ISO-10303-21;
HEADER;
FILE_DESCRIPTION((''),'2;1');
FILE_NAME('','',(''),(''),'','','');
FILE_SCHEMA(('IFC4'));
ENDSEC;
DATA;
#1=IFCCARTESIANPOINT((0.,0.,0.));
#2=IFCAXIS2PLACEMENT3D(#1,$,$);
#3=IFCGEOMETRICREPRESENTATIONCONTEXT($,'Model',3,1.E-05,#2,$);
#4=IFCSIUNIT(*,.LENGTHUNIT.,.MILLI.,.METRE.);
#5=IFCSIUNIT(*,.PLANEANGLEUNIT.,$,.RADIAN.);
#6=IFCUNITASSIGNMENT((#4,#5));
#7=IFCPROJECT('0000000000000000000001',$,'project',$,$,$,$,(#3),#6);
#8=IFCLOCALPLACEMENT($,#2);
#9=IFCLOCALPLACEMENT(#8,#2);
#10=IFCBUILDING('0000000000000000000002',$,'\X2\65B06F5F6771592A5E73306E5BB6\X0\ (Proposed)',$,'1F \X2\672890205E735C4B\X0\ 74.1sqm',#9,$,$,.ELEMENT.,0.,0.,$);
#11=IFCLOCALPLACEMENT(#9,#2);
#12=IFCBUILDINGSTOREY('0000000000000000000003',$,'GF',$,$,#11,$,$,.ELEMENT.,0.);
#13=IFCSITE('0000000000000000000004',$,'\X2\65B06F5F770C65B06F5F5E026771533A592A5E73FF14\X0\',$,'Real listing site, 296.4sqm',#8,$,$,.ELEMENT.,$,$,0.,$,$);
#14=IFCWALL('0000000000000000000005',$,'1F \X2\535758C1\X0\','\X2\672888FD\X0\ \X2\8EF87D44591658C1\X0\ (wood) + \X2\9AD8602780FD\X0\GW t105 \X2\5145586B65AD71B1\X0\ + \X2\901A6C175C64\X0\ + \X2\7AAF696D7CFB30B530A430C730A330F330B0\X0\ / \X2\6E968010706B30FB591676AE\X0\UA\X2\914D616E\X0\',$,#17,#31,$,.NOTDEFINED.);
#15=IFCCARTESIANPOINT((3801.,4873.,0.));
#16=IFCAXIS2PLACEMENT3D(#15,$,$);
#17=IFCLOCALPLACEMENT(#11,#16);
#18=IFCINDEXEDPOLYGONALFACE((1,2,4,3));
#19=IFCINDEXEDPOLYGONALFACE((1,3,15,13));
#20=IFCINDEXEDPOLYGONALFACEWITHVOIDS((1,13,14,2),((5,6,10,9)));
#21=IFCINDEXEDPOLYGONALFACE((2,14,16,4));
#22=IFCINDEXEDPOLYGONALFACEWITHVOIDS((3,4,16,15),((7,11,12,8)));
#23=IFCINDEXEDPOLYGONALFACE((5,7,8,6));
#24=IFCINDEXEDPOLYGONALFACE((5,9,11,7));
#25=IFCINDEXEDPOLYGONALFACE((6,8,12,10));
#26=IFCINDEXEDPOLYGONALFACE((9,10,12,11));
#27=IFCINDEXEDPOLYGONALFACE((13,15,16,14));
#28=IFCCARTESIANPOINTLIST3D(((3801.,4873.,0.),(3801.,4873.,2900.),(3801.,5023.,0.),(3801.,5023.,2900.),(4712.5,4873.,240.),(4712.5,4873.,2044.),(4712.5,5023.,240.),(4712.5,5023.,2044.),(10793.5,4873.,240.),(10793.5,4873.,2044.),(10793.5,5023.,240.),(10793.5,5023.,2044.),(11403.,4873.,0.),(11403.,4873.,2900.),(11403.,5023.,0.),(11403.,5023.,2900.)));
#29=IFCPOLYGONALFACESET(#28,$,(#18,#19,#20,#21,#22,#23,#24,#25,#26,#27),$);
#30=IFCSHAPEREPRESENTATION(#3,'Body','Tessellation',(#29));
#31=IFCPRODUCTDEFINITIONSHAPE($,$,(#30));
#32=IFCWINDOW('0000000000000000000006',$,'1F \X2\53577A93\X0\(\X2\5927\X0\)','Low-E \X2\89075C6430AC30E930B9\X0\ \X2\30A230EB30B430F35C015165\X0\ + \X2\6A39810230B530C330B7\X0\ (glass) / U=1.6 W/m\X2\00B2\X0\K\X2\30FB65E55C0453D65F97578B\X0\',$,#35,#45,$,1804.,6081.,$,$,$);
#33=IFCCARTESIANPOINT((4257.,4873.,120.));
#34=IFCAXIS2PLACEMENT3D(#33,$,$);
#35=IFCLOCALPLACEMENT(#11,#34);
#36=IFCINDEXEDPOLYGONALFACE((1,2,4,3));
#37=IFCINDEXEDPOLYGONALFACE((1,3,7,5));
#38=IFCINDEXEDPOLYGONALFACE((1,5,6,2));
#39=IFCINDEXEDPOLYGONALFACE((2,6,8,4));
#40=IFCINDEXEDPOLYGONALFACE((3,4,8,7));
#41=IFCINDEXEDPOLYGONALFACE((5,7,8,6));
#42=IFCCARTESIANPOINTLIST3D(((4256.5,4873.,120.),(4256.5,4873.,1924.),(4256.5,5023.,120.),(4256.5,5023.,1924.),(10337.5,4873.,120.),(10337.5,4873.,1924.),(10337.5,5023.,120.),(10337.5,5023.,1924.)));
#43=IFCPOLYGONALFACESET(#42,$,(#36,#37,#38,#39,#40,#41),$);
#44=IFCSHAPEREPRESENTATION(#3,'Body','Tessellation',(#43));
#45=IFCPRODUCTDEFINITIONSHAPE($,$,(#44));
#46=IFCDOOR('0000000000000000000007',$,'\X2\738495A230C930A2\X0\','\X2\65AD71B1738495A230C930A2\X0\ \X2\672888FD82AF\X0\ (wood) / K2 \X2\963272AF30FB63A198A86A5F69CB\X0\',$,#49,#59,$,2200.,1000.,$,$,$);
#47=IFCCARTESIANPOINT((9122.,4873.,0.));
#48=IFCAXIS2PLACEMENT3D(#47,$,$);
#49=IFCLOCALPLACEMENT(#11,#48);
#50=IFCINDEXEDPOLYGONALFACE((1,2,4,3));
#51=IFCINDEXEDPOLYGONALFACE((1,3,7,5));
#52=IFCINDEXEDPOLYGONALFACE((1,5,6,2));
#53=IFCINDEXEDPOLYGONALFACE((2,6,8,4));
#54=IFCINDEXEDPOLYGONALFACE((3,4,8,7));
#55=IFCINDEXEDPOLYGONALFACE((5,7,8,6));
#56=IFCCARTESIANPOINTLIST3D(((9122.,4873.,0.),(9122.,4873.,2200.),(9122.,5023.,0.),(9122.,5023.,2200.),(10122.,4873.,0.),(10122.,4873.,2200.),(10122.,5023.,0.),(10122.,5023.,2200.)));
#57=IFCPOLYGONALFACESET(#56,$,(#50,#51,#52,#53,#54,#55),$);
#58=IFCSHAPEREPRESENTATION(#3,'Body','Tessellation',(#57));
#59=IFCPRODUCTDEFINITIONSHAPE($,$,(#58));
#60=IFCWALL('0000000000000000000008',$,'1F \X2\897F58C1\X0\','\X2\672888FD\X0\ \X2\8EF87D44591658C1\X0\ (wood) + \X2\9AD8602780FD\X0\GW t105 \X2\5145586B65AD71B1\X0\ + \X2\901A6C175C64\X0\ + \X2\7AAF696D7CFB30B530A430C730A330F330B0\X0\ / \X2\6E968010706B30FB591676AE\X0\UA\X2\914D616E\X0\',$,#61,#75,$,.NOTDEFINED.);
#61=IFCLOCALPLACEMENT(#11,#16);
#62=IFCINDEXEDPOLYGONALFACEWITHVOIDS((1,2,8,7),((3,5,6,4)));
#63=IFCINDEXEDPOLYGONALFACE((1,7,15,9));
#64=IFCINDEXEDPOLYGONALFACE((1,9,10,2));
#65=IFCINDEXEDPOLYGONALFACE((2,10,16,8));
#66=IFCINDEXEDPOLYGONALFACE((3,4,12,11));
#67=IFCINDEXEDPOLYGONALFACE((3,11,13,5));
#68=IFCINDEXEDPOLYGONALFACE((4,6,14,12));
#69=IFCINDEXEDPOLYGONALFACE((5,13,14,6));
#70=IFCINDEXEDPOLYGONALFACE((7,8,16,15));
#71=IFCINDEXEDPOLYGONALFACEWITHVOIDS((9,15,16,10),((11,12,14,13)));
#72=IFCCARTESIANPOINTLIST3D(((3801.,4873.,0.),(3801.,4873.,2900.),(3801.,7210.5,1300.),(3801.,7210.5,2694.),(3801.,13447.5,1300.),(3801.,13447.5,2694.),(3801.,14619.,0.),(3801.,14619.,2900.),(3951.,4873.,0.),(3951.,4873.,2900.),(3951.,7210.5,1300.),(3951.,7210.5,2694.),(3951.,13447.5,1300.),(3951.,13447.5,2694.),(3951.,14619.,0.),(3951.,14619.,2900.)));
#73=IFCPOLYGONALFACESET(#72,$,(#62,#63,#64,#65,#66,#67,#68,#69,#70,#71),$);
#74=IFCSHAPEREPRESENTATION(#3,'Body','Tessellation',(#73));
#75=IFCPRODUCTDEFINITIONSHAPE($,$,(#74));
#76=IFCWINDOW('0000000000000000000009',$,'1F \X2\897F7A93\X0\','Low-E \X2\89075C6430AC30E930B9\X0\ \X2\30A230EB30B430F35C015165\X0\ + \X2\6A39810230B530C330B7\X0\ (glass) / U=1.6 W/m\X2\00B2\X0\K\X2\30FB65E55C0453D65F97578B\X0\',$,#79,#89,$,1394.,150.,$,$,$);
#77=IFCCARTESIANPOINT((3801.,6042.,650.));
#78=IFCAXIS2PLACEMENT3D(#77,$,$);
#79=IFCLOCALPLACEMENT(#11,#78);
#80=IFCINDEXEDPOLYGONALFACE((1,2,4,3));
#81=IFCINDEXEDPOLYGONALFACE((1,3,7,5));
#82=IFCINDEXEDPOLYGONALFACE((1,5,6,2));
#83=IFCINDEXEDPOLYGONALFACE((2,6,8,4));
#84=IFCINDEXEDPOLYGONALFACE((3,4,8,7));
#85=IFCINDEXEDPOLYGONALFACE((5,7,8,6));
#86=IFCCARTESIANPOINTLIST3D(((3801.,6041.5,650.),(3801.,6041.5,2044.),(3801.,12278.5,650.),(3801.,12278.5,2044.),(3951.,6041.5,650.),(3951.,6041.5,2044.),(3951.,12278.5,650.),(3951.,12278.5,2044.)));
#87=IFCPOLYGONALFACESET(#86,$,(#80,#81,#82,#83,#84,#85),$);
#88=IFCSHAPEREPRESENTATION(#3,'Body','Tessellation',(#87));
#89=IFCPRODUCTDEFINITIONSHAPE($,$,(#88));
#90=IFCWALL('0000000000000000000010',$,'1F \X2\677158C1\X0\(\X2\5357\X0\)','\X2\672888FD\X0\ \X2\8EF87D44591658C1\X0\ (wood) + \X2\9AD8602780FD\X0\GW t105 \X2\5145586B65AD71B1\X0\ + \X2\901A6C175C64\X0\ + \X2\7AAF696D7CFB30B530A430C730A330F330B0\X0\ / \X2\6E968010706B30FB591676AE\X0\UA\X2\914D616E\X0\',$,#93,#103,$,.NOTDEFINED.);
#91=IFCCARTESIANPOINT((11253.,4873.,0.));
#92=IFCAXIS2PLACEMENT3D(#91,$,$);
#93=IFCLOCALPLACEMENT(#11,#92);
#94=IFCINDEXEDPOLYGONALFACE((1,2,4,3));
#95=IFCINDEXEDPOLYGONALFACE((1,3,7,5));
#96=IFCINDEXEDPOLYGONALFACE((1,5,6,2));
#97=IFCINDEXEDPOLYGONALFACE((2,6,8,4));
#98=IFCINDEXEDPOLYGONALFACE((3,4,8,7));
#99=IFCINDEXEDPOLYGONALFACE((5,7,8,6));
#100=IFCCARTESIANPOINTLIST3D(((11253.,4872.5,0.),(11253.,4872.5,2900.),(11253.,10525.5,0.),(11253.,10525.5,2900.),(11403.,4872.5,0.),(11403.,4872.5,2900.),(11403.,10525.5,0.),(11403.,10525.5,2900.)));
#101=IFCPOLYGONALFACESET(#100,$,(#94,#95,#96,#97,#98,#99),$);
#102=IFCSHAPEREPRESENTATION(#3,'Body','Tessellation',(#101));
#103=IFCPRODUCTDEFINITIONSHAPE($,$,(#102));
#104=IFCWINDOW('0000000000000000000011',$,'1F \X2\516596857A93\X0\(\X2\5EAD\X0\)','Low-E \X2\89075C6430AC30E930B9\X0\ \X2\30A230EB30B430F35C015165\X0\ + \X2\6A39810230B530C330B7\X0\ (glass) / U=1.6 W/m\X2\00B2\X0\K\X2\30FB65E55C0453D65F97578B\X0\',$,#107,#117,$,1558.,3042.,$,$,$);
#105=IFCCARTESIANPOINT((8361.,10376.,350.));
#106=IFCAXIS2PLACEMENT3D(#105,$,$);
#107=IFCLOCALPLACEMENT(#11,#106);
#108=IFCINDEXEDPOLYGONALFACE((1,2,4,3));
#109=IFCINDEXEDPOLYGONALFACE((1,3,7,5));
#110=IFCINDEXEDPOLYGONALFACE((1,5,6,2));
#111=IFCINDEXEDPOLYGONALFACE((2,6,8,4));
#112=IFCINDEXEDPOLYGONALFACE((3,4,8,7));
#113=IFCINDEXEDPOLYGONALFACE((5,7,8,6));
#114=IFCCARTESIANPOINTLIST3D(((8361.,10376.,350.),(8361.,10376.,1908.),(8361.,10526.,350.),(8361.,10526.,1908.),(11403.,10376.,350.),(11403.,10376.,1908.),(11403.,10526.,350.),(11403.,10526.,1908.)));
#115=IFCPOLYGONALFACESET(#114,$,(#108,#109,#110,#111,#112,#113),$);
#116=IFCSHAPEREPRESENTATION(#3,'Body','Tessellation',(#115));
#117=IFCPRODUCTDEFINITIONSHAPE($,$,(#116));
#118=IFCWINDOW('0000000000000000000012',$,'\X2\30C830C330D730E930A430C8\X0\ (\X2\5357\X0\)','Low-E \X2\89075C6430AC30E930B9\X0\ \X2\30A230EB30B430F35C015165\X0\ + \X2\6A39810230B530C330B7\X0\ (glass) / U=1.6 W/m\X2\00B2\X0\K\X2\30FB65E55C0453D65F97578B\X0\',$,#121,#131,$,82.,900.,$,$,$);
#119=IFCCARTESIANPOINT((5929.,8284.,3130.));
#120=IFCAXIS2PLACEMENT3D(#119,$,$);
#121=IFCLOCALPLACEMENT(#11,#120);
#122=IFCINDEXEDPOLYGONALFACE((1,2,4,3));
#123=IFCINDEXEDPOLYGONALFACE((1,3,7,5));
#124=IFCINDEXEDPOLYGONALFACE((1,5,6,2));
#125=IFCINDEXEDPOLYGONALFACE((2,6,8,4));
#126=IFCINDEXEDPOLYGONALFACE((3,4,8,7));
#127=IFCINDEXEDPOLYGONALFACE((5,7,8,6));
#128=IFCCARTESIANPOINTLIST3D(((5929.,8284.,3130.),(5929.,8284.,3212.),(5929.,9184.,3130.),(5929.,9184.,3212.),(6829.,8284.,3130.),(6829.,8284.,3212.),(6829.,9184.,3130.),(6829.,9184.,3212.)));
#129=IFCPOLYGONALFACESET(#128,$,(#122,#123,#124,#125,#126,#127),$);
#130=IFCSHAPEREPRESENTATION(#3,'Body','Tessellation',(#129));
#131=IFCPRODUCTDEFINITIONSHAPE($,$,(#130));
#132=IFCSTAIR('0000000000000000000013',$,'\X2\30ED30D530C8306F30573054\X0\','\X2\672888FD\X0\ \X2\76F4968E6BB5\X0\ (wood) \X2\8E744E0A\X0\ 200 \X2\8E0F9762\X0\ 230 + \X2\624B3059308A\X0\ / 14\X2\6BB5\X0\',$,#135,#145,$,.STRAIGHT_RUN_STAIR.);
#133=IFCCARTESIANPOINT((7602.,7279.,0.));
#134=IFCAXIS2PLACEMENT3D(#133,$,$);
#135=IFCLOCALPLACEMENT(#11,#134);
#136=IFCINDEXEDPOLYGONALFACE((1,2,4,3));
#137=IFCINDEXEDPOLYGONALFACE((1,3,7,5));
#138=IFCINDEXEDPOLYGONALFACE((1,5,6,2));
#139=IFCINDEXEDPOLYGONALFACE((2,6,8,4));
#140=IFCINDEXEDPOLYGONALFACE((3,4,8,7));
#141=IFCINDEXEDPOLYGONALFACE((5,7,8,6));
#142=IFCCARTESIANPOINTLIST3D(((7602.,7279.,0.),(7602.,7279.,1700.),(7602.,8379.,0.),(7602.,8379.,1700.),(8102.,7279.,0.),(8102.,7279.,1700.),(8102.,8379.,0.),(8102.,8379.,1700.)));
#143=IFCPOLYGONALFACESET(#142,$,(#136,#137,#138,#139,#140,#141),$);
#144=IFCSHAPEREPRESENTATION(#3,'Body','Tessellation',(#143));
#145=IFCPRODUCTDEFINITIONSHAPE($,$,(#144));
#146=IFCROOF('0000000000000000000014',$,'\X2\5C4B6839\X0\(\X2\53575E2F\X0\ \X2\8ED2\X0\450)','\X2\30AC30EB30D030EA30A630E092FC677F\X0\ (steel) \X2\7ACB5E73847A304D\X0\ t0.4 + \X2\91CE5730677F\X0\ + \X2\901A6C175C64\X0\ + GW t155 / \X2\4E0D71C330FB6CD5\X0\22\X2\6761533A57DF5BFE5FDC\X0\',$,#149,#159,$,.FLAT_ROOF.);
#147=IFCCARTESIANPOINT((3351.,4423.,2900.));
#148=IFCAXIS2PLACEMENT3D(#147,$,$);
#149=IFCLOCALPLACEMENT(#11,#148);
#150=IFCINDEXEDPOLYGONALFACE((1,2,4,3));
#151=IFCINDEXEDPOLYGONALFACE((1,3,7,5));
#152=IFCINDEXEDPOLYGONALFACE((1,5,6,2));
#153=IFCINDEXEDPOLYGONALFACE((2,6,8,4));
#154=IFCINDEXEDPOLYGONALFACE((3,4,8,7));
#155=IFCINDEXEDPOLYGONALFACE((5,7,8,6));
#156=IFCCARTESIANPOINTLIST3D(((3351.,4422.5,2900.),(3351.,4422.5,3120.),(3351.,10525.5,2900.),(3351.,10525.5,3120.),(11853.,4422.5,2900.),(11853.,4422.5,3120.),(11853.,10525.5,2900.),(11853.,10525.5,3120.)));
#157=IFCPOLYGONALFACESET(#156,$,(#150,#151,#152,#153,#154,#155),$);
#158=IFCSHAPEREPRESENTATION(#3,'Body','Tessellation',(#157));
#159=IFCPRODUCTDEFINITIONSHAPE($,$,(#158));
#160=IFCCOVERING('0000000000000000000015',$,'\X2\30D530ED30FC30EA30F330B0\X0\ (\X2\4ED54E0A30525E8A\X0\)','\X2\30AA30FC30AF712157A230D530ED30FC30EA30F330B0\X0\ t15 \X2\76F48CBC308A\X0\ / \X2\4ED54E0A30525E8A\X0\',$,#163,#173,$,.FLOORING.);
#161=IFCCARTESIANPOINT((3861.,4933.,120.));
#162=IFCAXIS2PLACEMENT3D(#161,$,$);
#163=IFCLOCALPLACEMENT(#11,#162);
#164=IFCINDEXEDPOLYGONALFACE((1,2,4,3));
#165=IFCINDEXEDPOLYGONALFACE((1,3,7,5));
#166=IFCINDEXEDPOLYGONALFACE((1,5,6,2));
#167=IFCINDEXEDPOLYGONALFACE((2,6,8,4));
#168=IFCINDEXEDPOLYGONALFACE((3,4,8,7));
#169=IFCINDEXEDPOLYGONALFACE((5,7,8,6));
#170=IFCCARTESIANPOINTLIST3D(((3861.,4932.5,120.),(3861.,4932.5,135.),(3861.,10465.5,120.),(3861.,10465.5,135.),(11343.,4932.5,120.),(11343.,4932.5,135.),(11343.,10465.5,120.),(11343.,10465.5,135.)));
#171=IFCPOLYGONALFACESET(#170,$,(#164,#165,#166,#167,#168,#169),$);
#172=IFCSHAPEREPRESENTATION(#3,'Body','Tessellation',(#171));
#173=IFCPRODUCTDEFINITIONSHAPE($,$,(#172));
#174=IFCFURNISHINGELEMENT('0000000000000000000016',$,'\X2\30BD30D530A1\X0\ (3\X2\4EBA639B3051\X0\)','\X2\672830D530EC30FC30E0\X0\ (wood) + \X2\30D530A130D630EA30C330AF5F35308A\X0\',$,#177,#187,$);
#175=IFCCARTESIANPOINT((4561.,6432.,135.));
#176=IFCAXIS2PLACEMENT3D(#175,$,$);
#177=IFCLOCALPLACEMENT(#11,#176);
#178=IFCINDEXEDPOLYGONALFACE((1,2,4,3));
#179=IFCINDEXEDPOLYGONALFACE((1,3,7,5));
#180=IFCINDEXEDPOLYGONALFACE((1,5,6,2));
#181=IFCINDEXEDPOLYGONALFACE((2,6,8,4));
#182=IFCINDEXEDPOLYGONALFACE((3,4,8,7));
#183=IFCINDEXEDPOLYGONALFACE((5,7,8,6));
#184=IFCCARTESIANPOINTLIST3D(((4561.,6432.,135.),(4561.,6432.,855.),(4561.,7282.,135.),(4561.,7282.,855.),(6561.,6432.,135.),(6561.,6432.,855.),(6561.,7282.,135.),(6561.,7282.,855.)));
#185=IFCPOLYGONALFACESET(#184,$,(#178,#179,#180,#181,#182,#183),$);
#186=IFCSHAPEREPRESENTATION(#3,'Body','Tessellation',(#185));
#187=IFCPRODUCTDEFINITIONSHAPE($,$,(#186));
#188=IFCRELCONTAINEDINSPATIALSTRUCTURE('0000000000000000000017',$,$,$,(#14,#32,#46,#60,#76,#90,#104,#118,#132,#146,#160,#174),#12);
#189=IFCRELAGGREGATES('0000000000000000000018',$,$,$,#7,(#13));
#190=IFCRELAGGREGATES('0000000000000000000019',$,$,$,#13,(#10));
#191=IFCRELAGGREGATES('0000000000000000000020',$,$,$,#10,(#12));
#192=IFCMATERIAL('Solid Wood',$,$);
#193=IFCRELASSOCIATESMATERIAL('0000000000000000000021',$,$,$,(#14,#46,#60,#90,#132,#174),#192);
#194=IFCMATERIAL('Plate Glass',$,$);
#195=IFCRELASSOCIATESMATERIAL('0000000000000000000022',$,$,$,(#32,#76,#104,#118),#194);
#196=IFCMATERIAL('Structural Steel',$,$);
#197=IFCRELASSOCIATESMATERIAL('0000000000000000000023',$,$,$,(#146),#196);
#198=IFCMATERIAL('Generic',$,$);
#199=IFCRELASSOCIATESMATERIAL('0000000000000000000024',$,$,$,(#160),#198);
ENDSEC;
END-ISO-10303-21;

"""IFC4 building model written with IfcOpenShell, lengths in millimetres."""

from ifc_helpers import new_model, si_unit, frame, frame_2d, origin, place, context, project, spatial, rectangle, extrude, material, element, fill, save


model = new_model("IFC4")

# Units and contexts
model_context = context("Model", 3, precision=1e-05, world=origin())
ifc_project = project(units=[si_unit("LENGTHUNIT", "METRE", prefix="MILLI"), si_unit("PLANEANGLEUNIT", "RADIAN")], contexts=[model_context])

# Site, building, storey
site_placement = place(None, origin())
site = spatial("IfcSite", under=ifc_project, at=site_placement, Name="新潟県新潟市東区太平４", ObjectType="Real listing site, 296.4sqm", CompositionType="ELEMENT", RefElevation=0.0)
building_placement = place(site_placement, origin())
building = spatial("IfcBuilding", under=site, at=building_placement, Name="新潟東太平の家 (Proposed)", ObjectType="1F 木造平屋 74.1sqm", CompositionType="ELEMENT", ElevationOfRefHeight=0.0, ElevationOfTerrain=0.0)
storey_placement = place(building_placement, origin())
storey = spatial("IfcBuildingStorey", under=building, at=storey_placement, Name="GF", CompositionType="ELEMENT", Elevation=0.0)

# Shared definitions
ifc_material_1 = material(Name="Solid Wood")

# Wall, openings, window, door
wall_1_placement = place(storey_placement, frame((3801.0, 4873.0, 0.0)))
wall_1 = element("IfcWall", 1, at=wall_1_placement, inside=storey, material=ifc_material_1, Name="1F 南壁", Description="木製 軸組外壁 (wood) + 高性能GW t105 充填断熱 + 通気層 + 窯業系サイディング / 準耐火・外皮UA配慮", PredefinedType="NOTDEFINED", context=model_context, shape_type="SweptSolid", body=[
    extrude(rectangle(XDim=7602.0, YDim=150.0, at=frame_2d((3801.0, 75.0))), frame((3801.0, 4873.0, 0.0)), (0.0, 0.0, 1.0), 2900.0),
])
opening_1_placement = place(storey_placement, frame((4257.0, 4873.0, 120.0)))
opening_1 = element("IfcOpeningElement", 2, at=opening_1_placement, cuts=wall_1, PredefinedType="NOTDEFINED", context=model_context, shape_type="SweptSolid", body=[
    extrude(rectangle(XDim=6081.0, YDim=150.0, at=frame_2d((3040.0, 75.0))), frame((4257.0, 4873.0, 120.0)), (0.0, 0.0, 1.0), 1804.0),
])
opening_2_placement = place(storey_placement, frame((9122.0, 4873.0, 0.0)))
opening_2 = element("IfcOpeningElement", 3, at=opening_2_placement, cuts=wall_1, PredefinedType="NOTDEFINED", context=model_context, shape_type="SweptSolid", body=[
    extrude(rectangle(XDim=1000.0, YDim=150.0, at=frame_2d((500.0, 75.0))), frame((9122.0, 4873.0, 0.0)), (0.0, 0.0, 1.0), 2200.0),
])
ifc_material_2 = material(Name="Plate Glass")
window_1_placement = place(storey_placement, frame((4257.0, 4873.0, 120.0)))
window_1 = element("IfcWindow", 4, at=window_1_placement, inside=storey, material=ifc_material_2, Name="1F 南窓(大)", Description="Low-E 複層ガラス アルゴン封入 + 樹脂サッシ (glass) / U=1.6 W/m²K・日射取得型", OverallHeight=1804.0, OverallWidth=6081.0, context=model_context, shape_type="SweptSolid", body=[
    extrude(rectangle(XDim=6081.0, YDim=150.0, at=frame_2d((3040.0, 75.0))), frame((4257.0, 4873.0, 120.0)), (0.0, 0.0, 1.0), 1804.0),
])
fill(opening_1, window_1)
door_1_placement = place(storey_placement, frame((9122.0, 4873.0, 0.0)))
door_1 = element("IfcDoor", 5, at=door_1_placement, inside=storey, material=ifc_material_1, Name="玄関ドア", Description="断熱玄関ドア 木製芯 (wood) / K2 防犯・採風機構", OverallHeight=2200.0, OverallWidth=1000.0, context=model_context, shape_type="SweptSolid", body=[
    extrude(rectangle(XDim=1000.0, YDim=150.0, at=frame_2d((500.0, 75.0))), frame((9122.0, 4873.0, 0.0)), (0.0, 0.0, 1.0), 2200.0),
])
fill(opening_2, door_1)

# Walls, openings, windows
wall_2_placement = place(storey_placement, frame((3801.0, 4873.0, 0.0)))
wall_2 = element("IfcWall", 6, at=wall_2_placement, inside=storey, material=ifc_material_1, Name="1F 西壁", Description="木製 軸組外壁 (wood) + 高性能GW t105 充填断熱 + 通気層 + 窯業系サイディング / 準耐火・外皮UA配慮", PredefinedType="NOTDEFINED", context=model_context, shape_type="SweptSolid", body=[
    extrude(rectangle(XDim=150.0, YDim=9746.0, at=frame_2d((75.0, 4873.0))), frame((3801.0, 4873.0, 0.0)), (0.0, 0.0, 1.0), 2900.0),
])
opening_3_placement = place(storey_placement, frame((3801.0, 6042.0, 650.0)))
opening_3 = element("IfcOpeningElement", 7, at=opening_3_placement, cuts=wall_2, PredefinedType="NOTDEFINED", context=model_context, shape_type="SweptSolid", body=[
    extrude(rectangle(XDim=150.0, YDim=6237.0, at=frame_2d((75.0, 3118.0))), frame((3801.0, 6042.0, 650.0)), (0.0, 0.0, 1.0), 1394.0),
])
window_2_placement = place(storey_placement, frame((3801.0, 6042.0, 650.0)))
window_2 = element("IfcWindow", 8, at=window_2_placement, inside=storey, material=ifc_material_2, Name="1F 西窓", Description="Low-E 複層ガラス アルゴン封入 + 樹脂サッシ (glass) / U=1.6 W/m²K・日射取得型", OverallHeight=1394.0, OverallWidth=150.0, context=model_context, shape_type="SweptSolid", body=[
    extrude(rectangle(XDim=150.0, YDim=6237.0, at=frame_2d((75.0, 3118.0))), frame((3801.0, 6042.0, 650.0)), (0.0, 0.0, 1.0), 1394.0),
])
fill(opening_3, window_2)
wall_3_placement = place(storey_placement, frame((11253.0, 4873.0, 0.0)))
wall_3 = element("IfcWall", 9, at=wall_3_placement, inside=storey, material=ifc_material_1, Name="1F 東壁(南)", Description="木製 軸組外壁 (wood) + 高性能GW t105 充填断熱 + 通気層 + 窯業系サイディング / 準耐火・外皮UA配慮", PredefinedType="NOTDEFINED", context=model_context, shape_type="SweptSolid", body=[
    extrude(rectangle(XDim=150.0, YDim=5653.0, at=frame_2d((75.0, 2826.0))), frame((11253.0, 4873.0, 0.0)), (0.0, 0.0, 1.0), 2900.0),
])
opening_4_placement = place(storey_placement, frame((8361.0, 10376.0, 350.0)))
opening_4 = element("IfcOpeningElement", 10, at=opening_4_placement, cuts=wall_3, PredefinedType="NOTDEFINED", context=model_context, shape_type="SweptSolid", body=[
    extrude(rectangle(XDim=3042.0, YDim=150.0, at=frame_2d((1521.0, 75.0))), frame((8361.0, 10376.0, 350.0)), (0.0, 0.0, 1.0), 1558.0),
])
window_3_placement = place(storey_placement, frame((8361.0, 10376.0, 350.0)))
window_3 = element("IfcWindow", 11, at=window_3_placement, inside=storey, material=ifc_material_2, Name="1F 入隅窓(庭)", Description="Low-E 複層ガラス アルゴン封入 + 樹脂サッシ (glass) / U=1.6 W/m²K・日射取得型", OverallHeight=1558.0, OverallWidth=3042.0, context=model_context, shape_type="SweptSolid", body=[
    extrude(rectangle(XDim=3042.0, YDim=150.0, at=frame_2d((1521.0, 75.0))), frame((8361.0, 10376.0, 350.0)), (0.0, 0.0, 1.0), 1558.0),
])
fill(opening_4, window_3)

# Window
window_4_placement = place(storey_placement, frame((5929.0, 8284.0, 3130.0)))
element("IfcWindow", 12, at=window_4_placement, inside=storey, material=ifc_material_2, Name="トップライト (南)", Description="Low-E 複層ガラス アルゴン封入 + 樹脂サッシ (glass) / U=1.6 W/m²K・日射取得型", OverallHeight=82.0, OverallWidth=900.0, context=model_context, shape_type="SweptSolid", body=[
    extrude(rectangle(XDim=900.0, YDim=900.0, at=frame_2d((450.0, 450.0))), frame((5929.0, 8284.0, 3130.0)), (0.0, 0.0, 1.0), 82.0),
])

# Stair
stair_placement = place(storey_placement, frame((7602.0, 7279.0, 0.0)))
element("IfcStair", 13, at=stair_placement, inside=storey, material=ifc_material_1, Name="ロフトはしご", Description="木製 直階段 (wood) 蹴上 200 踏面 230 + 手すり / 14段", PredefinedType="STRAIGHT_RUN_STAIR", context=model_context, shape_type="SweptSolid", body=[
    extrude(rectangle(XDim=500.0, YDim=1100.0, at=frame_2d((250.0, 550.0))), frame((7602.0, 7279.0, 0.0)), (0.0, 0.0, 1.0), 1700.0),
])

# Roof
ifc_material_3 = material(Name="Structural Steel")
roof_placement = place(storey_placement, frame((3351.0, 4423.0, 2900.0)))
element("IfcRoof", 14, at=roof_placement, inside=storey, material=ifc_material_3, Name="屋根(南帯 軒450)", Description="ガルバリウム鋼板 (steel) 立平葺き t0.4 + 野地板 + 通気層 + GW t155 / 不燃・法22条区域対応", PredefinedType="FLAT_ROOF", context=model_context, shape_type="SweptSolid", body=[
    extrude(rectangle(XDim=8502.0, YDim=6103.0, at=frame_2d((4251.0, 3051.0))), frame((3351.0, 4423.0, 2900.0)), (0.0, 0.0, 1.0), 220.0),
])

# Covering
ifc_material_4 = material(Name="Generic")
covering_placement = place(storey_placement, frame((3861.0, 4933.0, 120.0)))
element("IfcCovering", 15, at=covering_placement, inside=storey, material=ifc_material_4, Name="フローリング (仕上げ床)", Description="オーク無垢フローリング t15 直貼り / 仕上げ床", PredefinedType="FLOORING", context=model_context, shape_type="SweptSolid", body=[
    extrude(rectangle(XDim=7482.0, YDim=5533.0, at=frame_2d((3741.0, 2766.0))), frame((3861.0, 4933.0, 120.0)), (0.0, 0.0, 1.0), 15.0),
])

# Furnishing element
furnishing_1_placement = place(storey_placement, frame((4561.0, 6432.0, 135.0)))
element("IfcFurnishingElement", 16, at=furnishing_1_placement, inside=storey, material=ifc_material_1, Name="ソファ (3人掛け)", Description="木フレーム (wood) + ファブリック張り", context=model_context, shape_type="SweptSolid", body=[
    extrude(rectangle(XDim=2000.0, YDim=850.0, at=frame_2d((1000.0, 425.0))), frame((4561.0, 6432.0, 135.0)), (0.0, 0.0, 1.0), 720.0),
])

save(model, "model.ifc")
